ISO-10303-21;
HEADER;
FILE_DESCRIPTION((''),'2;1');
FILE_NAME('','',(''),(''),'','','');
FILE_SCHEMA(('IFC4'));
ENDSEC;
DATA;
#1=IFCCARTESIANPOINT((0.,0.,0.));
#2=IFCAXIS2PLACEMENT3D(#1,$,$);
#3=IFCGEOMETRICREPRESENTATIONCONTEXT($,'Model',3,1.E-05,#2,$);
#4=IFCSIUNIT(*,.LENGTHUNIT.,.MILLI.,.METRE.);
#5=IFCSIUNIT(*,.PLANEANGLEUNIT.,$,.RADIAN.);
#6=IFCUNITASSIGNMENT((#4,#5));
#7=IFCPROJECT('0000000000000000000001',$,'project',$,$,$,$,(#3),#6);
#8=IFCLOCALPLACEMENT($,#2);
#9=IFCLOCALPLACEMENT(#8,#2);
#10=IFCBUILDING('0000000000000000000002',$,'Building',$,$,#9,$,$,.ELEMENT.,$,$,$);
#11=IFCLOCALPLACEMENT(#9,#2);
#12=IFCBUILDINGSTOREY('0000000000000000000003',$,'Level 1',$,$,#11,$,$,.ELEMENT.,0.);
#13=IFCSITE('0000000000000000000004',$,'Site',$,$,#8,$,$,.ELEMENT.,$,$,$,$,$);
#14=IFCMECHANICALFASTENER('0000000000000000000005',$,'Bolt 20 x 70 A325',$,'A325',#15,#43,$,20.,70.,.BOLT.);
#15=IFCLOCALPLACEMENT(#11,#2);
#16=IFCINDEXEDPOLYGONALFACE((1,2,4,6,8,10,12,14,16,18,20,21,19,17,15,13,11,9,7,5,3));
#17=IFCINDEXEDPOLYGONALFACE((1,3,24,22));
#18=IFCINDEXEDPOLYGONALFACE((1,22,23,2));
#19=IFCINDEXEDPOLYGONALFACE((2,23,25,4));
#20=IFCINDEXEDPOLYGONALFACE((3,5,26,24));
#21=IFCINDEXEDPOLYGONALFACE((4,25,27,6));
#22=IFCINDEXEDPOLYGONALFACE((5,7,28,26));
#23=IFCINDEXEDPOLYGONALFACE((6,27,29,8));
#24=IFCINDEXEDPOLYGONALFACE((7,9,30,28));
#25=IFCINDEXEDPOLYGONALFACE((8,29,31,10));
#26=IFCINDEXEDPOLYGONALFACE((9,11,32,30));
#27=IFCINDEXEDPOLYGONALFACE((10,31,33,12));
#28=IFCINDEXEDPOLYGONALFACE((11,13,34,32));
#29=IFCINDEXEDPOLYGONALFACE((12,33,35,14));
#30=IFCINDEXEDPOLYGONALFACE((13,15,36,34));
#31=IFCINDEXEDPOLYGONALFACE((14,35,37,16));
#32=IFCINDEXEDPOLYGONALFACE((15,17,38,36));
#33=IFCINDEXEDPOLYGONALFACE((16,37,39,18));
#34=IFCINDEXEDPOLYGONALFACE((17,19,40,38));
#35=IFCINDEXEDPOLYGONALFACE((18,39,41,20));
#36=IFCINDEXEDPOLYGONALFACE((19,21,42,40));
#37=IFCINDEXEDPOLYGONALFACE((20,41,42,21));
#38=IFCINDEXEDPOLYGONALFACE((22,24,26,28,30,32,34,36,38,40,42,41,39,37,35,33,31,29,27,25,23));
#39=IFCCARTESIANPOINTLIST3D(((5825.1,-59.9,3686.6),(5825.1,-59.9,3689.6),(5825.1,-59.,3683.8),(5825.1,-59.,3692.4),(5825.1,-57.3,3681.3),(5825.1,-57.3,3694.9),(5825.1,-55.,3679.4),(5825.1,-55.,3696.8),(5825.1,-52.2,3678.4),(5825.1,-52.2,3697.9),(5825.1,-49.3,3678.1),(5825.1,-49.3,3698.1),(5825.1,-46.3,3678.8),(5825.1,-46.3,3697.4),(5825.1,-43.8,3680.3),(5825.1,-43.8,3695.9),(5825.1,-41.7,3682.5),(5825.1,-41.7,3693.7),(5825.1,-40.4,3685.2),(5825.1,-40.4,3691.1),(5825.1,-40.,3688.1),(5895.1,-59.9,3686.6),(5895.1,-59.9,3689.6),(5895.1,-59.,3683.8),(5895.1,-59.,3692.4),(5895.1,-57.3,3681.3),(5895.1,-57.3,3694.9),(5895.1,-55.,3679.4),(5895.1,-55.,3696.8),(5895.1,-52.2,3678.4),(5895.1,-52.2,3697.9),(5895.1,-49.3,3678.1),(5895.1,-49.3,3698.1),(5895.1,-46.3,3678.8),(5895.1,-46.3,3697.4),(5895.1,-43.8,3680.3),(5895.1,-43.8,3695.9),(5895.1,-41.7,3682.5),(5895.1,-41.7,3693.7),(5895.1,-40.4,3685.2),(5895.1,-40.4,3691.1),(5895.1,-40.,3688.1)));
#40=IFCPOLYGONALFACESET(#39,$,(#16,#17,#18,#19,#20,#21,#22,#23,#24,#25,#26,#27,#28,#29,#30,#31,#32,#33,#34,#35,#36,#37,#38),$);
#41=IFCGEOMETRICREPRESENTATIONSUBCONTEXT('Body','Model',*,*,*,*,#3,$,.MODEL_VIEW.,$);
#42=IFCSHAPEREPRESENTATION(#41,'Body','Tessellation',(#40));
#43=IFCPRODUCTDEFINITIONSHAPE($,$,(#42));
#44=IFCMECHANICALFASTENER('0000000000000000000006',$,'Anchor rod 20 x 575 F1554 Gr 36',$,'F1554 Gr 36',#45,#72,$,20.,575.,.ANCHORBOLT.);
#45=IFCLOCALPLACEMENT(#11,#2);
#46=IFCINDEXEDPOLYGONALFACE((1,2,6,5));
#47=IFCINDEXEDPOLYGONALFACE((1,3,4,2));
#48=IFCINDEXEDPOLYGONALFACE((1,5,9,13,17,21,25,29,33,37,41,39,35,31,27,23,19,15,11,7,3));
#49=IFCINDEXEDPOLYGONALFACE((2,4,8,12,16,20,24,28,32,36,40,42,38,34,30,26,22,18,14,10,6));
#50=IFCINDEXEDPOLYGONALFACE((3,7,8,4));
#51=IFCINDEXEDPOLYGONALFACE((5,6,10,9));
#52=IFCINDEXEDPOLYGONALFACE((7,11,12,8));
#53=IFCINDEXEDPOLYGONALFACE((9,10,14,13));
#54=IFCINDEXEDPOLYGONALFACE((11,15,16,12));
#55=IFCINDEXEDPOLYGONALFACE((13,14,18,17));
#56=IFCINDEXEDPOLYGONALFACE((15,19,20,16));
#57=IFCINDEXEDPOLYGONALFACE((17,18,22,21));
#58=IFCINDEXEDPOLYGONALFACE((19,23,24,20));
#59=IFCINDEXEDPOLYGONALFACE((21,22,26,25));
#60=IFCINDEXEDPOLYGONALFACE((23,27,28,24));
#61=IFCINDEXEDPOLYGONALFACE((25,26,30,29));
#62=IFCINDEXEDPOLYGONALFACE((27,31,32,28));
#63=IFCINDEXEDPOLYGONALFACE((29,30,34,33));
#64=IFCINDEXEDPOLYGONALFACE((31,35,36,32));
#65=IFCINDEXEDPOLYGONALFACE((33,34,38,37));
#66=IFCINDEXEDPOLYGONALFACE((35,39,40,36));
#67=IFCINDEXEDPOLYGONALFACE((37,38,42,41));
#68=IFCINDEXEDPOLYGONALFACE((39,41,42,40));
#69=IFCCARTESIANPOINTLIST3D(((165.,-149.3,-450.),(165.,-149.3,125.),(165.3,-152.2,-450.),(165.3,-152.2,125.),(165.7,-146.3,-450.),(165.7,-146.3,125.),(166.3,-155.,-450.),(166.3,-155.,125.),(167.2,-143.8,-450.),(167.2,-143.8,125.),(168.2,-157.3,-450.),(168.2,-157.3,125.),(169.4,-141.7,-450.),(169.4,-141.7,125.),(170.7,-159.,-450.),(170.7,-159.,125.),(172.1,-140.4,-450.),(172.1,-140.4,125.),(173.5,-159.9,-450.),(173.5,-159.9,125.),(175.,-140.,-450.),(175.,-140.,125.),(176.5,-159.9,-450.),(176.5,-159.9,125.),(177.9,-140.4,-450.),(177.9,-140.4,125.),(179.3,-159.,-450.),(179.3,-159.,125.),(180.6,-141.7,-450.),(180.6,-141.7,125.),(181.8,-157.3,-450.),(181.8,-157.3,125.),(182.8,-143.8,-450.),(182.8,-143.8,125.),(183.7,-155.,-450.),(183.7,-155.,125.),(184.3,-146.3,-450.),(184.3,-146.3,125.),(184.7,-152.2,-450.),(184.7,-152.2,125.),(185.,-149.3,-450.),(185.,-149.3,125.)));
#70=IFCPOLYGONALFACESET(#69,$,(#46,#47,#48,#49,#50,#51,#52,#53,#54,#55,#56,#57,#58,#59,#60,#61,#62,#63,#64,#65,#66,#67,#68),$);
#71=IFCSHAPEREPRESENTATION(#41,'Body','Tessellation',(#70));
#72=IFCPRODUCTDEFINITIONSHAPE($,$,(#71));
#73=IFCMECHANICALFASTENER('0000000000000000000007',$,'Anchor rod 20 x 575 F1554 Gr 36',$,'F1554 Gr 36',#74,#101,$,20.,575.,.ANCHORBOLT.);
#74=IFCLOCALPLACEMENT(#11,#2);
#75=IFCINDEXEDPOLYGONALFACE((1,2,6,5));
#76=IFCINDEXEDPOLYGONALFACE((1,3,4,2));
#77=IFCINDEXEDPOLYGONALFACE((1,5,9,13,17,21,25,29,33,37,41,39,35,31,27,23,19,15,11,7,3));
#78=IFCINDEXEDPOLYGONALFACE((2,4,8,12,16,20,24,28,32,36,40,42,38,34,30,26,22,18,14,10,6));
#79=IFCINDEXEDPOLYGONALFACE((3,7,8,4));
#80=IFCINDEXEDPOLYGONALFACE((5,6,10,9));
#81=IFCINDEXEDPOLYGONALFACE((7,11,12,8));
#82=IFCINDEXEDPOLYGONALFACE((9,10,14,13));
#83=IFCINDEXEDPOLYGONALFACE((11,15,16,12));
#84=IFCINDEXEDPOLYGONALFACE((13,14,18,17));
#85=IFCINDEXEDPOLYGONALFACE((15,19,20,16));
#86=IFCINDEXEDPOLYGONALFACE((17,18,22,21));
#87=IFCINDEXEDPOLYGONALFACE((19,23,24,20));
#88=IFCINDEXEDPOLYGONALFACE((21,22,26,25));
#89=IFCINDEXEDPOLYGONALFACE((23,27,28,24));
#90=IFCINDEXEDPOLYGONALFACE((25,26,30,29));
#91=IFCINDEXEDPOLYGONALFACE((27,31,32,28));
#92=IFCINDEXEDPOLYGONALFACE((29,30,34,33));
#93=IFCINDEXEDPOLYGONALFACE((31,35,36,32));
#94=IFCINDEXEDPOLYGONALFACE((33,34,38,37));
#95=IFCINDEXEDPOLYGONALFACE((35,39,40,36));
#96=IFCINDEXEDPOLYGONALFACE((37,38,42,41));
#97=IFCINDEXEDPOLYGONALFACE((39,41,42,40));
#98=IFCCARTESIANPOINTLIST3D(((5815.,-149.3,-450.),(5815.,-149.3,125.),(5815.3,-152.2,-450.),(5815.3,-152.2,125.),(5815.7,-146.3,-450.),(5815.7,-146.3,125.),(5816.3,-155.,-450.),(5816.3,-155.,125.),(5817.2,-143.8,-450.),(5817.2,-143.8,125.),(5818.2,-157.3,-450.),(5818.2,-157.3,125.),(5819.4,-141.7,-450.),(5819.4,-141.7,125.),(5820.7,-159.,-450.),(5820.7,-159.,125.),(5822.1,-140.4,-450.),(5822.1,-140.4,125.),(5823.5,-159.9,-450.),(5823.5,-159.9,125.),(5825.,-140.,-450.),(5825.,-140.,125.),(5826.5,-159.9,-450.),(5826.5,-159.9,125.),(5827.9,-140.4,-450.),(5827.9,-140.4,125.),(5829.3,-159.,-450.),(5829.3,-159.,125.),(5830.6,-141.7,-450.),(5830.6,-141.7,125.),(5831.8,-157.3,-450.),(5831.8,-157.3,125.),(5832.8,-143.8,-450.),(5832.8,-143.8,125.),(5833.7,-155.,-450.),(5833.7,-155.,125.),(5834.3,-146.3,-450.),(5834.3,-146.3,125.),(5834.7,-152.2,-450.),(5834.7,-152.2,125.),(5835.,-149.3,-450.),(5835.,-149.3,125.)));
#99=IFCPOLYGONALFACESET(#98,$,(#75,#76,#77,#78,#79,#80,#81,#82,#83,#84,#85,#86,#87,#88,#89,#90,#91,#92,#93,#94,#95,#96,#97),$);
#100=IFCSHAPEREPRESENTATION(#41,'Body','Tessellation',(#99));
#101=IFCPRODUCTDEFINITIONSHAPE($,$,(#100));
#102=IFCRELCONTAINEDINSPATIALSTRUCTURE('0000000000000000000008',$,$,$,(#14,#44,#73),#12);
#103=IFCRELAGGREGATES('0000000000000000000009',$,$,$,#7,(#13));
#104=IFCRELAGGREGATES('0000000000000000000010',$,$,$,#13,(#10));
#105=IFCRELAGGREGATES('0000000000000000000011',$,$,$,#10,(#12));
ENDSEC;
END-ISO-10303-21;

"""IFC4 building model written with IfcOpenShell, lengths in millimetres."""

from ifc_helpers import new_model, si_unit, frame, origin, origin_2d, place, context, subcontext, project, spatial, circle, extrude, element, save


model = new_model("IFC4")

# Units and contexts
model_context = context("Model", 3, precision=1e-05, world=origin())
body_context = subcontext(model_context, "Body", "Model", "MODEL_VIEW")
ifc_project = project(units=[si_unit("LENGTHUNIT", "METRE", prefix="MILLI"), si_unit("PLANEANGLEUNIT", "RADIAN")], contexts=[model_context])

# Site, building, storey
site_placement = place(None, origin())
site = spatial("IfcSite", under=ifc_project, at=site_placement, Name="Site", CompositionType="ELEMENT")
building_placement = place(site_placement, origin())
building = spatial("IfcBuilding", under=site, at=building_placement, Name="Building", CompositionType="ELEMENT")
storey_placement = place(building_placement, origin())
storey = spatial("IfcBuildingStorey", under=building, at=storey_placement, Name="Level 1", CompositionType="ELEMENT", Elevation=0.0)

# Mechanical fasteners
for number, where, z_axis, x_axis, name in (
    (1, (5825.1, -50.0, 3688.1), (1.0, 0.0, 0.0), (0.0, 1.0, 0.0), "Bolt 20 x 70 A325"),
):
    element("IfcMechanicalFastener", number, at=place(storey_placement, frame(where, z_axis=z_axis, x_axis=x_axis)), inside=storey, Name=name, ObjectType="A325", NominalDiameter=20.0, NominalLength=70.0, PredefinedType="BOLT", context=body_context, shape_type="SweptSolid", body=[
        extrude(circle(Radius=10.0, at=origin_2d()), origin(), (0.0, 0.0, 1.0), 70.0),
    ])
for number, where, z_axis, x_axis, name in (
    (2, (175.0, -150.0, 125.0), (0.0, 0.0, -1.0), (0.0, 1.0, 0.0), "Anchor rod 20 x 575 F1554 Gr 36"),
    (3, (5825.0, -150.0, 125.0), (0.0, 0.0, -1.0), (0.0, 1.0, 0.0), "Anchor rod 20 x 575 F1554 Gr 36"),
):
    element("IfcMechanicalFastener", number, at=place(storey_placement, frame(where, z_axis=z_axis, x_axis=x_axis)), inside=storey, Name=name, ObjectType="F1554 Gr 36", NominalDiameter=20.0, NominalLength=575.0, PredefinedType="ANCHORBOLT", context=body_context, shape_type="SweptSolid", body=[
        extrude(circle(Radius=10.0, at=origin_2d()), origin(), (0.0, 0.0, 1.0), 575.0),
    ])

save(model, "model.ifc")
